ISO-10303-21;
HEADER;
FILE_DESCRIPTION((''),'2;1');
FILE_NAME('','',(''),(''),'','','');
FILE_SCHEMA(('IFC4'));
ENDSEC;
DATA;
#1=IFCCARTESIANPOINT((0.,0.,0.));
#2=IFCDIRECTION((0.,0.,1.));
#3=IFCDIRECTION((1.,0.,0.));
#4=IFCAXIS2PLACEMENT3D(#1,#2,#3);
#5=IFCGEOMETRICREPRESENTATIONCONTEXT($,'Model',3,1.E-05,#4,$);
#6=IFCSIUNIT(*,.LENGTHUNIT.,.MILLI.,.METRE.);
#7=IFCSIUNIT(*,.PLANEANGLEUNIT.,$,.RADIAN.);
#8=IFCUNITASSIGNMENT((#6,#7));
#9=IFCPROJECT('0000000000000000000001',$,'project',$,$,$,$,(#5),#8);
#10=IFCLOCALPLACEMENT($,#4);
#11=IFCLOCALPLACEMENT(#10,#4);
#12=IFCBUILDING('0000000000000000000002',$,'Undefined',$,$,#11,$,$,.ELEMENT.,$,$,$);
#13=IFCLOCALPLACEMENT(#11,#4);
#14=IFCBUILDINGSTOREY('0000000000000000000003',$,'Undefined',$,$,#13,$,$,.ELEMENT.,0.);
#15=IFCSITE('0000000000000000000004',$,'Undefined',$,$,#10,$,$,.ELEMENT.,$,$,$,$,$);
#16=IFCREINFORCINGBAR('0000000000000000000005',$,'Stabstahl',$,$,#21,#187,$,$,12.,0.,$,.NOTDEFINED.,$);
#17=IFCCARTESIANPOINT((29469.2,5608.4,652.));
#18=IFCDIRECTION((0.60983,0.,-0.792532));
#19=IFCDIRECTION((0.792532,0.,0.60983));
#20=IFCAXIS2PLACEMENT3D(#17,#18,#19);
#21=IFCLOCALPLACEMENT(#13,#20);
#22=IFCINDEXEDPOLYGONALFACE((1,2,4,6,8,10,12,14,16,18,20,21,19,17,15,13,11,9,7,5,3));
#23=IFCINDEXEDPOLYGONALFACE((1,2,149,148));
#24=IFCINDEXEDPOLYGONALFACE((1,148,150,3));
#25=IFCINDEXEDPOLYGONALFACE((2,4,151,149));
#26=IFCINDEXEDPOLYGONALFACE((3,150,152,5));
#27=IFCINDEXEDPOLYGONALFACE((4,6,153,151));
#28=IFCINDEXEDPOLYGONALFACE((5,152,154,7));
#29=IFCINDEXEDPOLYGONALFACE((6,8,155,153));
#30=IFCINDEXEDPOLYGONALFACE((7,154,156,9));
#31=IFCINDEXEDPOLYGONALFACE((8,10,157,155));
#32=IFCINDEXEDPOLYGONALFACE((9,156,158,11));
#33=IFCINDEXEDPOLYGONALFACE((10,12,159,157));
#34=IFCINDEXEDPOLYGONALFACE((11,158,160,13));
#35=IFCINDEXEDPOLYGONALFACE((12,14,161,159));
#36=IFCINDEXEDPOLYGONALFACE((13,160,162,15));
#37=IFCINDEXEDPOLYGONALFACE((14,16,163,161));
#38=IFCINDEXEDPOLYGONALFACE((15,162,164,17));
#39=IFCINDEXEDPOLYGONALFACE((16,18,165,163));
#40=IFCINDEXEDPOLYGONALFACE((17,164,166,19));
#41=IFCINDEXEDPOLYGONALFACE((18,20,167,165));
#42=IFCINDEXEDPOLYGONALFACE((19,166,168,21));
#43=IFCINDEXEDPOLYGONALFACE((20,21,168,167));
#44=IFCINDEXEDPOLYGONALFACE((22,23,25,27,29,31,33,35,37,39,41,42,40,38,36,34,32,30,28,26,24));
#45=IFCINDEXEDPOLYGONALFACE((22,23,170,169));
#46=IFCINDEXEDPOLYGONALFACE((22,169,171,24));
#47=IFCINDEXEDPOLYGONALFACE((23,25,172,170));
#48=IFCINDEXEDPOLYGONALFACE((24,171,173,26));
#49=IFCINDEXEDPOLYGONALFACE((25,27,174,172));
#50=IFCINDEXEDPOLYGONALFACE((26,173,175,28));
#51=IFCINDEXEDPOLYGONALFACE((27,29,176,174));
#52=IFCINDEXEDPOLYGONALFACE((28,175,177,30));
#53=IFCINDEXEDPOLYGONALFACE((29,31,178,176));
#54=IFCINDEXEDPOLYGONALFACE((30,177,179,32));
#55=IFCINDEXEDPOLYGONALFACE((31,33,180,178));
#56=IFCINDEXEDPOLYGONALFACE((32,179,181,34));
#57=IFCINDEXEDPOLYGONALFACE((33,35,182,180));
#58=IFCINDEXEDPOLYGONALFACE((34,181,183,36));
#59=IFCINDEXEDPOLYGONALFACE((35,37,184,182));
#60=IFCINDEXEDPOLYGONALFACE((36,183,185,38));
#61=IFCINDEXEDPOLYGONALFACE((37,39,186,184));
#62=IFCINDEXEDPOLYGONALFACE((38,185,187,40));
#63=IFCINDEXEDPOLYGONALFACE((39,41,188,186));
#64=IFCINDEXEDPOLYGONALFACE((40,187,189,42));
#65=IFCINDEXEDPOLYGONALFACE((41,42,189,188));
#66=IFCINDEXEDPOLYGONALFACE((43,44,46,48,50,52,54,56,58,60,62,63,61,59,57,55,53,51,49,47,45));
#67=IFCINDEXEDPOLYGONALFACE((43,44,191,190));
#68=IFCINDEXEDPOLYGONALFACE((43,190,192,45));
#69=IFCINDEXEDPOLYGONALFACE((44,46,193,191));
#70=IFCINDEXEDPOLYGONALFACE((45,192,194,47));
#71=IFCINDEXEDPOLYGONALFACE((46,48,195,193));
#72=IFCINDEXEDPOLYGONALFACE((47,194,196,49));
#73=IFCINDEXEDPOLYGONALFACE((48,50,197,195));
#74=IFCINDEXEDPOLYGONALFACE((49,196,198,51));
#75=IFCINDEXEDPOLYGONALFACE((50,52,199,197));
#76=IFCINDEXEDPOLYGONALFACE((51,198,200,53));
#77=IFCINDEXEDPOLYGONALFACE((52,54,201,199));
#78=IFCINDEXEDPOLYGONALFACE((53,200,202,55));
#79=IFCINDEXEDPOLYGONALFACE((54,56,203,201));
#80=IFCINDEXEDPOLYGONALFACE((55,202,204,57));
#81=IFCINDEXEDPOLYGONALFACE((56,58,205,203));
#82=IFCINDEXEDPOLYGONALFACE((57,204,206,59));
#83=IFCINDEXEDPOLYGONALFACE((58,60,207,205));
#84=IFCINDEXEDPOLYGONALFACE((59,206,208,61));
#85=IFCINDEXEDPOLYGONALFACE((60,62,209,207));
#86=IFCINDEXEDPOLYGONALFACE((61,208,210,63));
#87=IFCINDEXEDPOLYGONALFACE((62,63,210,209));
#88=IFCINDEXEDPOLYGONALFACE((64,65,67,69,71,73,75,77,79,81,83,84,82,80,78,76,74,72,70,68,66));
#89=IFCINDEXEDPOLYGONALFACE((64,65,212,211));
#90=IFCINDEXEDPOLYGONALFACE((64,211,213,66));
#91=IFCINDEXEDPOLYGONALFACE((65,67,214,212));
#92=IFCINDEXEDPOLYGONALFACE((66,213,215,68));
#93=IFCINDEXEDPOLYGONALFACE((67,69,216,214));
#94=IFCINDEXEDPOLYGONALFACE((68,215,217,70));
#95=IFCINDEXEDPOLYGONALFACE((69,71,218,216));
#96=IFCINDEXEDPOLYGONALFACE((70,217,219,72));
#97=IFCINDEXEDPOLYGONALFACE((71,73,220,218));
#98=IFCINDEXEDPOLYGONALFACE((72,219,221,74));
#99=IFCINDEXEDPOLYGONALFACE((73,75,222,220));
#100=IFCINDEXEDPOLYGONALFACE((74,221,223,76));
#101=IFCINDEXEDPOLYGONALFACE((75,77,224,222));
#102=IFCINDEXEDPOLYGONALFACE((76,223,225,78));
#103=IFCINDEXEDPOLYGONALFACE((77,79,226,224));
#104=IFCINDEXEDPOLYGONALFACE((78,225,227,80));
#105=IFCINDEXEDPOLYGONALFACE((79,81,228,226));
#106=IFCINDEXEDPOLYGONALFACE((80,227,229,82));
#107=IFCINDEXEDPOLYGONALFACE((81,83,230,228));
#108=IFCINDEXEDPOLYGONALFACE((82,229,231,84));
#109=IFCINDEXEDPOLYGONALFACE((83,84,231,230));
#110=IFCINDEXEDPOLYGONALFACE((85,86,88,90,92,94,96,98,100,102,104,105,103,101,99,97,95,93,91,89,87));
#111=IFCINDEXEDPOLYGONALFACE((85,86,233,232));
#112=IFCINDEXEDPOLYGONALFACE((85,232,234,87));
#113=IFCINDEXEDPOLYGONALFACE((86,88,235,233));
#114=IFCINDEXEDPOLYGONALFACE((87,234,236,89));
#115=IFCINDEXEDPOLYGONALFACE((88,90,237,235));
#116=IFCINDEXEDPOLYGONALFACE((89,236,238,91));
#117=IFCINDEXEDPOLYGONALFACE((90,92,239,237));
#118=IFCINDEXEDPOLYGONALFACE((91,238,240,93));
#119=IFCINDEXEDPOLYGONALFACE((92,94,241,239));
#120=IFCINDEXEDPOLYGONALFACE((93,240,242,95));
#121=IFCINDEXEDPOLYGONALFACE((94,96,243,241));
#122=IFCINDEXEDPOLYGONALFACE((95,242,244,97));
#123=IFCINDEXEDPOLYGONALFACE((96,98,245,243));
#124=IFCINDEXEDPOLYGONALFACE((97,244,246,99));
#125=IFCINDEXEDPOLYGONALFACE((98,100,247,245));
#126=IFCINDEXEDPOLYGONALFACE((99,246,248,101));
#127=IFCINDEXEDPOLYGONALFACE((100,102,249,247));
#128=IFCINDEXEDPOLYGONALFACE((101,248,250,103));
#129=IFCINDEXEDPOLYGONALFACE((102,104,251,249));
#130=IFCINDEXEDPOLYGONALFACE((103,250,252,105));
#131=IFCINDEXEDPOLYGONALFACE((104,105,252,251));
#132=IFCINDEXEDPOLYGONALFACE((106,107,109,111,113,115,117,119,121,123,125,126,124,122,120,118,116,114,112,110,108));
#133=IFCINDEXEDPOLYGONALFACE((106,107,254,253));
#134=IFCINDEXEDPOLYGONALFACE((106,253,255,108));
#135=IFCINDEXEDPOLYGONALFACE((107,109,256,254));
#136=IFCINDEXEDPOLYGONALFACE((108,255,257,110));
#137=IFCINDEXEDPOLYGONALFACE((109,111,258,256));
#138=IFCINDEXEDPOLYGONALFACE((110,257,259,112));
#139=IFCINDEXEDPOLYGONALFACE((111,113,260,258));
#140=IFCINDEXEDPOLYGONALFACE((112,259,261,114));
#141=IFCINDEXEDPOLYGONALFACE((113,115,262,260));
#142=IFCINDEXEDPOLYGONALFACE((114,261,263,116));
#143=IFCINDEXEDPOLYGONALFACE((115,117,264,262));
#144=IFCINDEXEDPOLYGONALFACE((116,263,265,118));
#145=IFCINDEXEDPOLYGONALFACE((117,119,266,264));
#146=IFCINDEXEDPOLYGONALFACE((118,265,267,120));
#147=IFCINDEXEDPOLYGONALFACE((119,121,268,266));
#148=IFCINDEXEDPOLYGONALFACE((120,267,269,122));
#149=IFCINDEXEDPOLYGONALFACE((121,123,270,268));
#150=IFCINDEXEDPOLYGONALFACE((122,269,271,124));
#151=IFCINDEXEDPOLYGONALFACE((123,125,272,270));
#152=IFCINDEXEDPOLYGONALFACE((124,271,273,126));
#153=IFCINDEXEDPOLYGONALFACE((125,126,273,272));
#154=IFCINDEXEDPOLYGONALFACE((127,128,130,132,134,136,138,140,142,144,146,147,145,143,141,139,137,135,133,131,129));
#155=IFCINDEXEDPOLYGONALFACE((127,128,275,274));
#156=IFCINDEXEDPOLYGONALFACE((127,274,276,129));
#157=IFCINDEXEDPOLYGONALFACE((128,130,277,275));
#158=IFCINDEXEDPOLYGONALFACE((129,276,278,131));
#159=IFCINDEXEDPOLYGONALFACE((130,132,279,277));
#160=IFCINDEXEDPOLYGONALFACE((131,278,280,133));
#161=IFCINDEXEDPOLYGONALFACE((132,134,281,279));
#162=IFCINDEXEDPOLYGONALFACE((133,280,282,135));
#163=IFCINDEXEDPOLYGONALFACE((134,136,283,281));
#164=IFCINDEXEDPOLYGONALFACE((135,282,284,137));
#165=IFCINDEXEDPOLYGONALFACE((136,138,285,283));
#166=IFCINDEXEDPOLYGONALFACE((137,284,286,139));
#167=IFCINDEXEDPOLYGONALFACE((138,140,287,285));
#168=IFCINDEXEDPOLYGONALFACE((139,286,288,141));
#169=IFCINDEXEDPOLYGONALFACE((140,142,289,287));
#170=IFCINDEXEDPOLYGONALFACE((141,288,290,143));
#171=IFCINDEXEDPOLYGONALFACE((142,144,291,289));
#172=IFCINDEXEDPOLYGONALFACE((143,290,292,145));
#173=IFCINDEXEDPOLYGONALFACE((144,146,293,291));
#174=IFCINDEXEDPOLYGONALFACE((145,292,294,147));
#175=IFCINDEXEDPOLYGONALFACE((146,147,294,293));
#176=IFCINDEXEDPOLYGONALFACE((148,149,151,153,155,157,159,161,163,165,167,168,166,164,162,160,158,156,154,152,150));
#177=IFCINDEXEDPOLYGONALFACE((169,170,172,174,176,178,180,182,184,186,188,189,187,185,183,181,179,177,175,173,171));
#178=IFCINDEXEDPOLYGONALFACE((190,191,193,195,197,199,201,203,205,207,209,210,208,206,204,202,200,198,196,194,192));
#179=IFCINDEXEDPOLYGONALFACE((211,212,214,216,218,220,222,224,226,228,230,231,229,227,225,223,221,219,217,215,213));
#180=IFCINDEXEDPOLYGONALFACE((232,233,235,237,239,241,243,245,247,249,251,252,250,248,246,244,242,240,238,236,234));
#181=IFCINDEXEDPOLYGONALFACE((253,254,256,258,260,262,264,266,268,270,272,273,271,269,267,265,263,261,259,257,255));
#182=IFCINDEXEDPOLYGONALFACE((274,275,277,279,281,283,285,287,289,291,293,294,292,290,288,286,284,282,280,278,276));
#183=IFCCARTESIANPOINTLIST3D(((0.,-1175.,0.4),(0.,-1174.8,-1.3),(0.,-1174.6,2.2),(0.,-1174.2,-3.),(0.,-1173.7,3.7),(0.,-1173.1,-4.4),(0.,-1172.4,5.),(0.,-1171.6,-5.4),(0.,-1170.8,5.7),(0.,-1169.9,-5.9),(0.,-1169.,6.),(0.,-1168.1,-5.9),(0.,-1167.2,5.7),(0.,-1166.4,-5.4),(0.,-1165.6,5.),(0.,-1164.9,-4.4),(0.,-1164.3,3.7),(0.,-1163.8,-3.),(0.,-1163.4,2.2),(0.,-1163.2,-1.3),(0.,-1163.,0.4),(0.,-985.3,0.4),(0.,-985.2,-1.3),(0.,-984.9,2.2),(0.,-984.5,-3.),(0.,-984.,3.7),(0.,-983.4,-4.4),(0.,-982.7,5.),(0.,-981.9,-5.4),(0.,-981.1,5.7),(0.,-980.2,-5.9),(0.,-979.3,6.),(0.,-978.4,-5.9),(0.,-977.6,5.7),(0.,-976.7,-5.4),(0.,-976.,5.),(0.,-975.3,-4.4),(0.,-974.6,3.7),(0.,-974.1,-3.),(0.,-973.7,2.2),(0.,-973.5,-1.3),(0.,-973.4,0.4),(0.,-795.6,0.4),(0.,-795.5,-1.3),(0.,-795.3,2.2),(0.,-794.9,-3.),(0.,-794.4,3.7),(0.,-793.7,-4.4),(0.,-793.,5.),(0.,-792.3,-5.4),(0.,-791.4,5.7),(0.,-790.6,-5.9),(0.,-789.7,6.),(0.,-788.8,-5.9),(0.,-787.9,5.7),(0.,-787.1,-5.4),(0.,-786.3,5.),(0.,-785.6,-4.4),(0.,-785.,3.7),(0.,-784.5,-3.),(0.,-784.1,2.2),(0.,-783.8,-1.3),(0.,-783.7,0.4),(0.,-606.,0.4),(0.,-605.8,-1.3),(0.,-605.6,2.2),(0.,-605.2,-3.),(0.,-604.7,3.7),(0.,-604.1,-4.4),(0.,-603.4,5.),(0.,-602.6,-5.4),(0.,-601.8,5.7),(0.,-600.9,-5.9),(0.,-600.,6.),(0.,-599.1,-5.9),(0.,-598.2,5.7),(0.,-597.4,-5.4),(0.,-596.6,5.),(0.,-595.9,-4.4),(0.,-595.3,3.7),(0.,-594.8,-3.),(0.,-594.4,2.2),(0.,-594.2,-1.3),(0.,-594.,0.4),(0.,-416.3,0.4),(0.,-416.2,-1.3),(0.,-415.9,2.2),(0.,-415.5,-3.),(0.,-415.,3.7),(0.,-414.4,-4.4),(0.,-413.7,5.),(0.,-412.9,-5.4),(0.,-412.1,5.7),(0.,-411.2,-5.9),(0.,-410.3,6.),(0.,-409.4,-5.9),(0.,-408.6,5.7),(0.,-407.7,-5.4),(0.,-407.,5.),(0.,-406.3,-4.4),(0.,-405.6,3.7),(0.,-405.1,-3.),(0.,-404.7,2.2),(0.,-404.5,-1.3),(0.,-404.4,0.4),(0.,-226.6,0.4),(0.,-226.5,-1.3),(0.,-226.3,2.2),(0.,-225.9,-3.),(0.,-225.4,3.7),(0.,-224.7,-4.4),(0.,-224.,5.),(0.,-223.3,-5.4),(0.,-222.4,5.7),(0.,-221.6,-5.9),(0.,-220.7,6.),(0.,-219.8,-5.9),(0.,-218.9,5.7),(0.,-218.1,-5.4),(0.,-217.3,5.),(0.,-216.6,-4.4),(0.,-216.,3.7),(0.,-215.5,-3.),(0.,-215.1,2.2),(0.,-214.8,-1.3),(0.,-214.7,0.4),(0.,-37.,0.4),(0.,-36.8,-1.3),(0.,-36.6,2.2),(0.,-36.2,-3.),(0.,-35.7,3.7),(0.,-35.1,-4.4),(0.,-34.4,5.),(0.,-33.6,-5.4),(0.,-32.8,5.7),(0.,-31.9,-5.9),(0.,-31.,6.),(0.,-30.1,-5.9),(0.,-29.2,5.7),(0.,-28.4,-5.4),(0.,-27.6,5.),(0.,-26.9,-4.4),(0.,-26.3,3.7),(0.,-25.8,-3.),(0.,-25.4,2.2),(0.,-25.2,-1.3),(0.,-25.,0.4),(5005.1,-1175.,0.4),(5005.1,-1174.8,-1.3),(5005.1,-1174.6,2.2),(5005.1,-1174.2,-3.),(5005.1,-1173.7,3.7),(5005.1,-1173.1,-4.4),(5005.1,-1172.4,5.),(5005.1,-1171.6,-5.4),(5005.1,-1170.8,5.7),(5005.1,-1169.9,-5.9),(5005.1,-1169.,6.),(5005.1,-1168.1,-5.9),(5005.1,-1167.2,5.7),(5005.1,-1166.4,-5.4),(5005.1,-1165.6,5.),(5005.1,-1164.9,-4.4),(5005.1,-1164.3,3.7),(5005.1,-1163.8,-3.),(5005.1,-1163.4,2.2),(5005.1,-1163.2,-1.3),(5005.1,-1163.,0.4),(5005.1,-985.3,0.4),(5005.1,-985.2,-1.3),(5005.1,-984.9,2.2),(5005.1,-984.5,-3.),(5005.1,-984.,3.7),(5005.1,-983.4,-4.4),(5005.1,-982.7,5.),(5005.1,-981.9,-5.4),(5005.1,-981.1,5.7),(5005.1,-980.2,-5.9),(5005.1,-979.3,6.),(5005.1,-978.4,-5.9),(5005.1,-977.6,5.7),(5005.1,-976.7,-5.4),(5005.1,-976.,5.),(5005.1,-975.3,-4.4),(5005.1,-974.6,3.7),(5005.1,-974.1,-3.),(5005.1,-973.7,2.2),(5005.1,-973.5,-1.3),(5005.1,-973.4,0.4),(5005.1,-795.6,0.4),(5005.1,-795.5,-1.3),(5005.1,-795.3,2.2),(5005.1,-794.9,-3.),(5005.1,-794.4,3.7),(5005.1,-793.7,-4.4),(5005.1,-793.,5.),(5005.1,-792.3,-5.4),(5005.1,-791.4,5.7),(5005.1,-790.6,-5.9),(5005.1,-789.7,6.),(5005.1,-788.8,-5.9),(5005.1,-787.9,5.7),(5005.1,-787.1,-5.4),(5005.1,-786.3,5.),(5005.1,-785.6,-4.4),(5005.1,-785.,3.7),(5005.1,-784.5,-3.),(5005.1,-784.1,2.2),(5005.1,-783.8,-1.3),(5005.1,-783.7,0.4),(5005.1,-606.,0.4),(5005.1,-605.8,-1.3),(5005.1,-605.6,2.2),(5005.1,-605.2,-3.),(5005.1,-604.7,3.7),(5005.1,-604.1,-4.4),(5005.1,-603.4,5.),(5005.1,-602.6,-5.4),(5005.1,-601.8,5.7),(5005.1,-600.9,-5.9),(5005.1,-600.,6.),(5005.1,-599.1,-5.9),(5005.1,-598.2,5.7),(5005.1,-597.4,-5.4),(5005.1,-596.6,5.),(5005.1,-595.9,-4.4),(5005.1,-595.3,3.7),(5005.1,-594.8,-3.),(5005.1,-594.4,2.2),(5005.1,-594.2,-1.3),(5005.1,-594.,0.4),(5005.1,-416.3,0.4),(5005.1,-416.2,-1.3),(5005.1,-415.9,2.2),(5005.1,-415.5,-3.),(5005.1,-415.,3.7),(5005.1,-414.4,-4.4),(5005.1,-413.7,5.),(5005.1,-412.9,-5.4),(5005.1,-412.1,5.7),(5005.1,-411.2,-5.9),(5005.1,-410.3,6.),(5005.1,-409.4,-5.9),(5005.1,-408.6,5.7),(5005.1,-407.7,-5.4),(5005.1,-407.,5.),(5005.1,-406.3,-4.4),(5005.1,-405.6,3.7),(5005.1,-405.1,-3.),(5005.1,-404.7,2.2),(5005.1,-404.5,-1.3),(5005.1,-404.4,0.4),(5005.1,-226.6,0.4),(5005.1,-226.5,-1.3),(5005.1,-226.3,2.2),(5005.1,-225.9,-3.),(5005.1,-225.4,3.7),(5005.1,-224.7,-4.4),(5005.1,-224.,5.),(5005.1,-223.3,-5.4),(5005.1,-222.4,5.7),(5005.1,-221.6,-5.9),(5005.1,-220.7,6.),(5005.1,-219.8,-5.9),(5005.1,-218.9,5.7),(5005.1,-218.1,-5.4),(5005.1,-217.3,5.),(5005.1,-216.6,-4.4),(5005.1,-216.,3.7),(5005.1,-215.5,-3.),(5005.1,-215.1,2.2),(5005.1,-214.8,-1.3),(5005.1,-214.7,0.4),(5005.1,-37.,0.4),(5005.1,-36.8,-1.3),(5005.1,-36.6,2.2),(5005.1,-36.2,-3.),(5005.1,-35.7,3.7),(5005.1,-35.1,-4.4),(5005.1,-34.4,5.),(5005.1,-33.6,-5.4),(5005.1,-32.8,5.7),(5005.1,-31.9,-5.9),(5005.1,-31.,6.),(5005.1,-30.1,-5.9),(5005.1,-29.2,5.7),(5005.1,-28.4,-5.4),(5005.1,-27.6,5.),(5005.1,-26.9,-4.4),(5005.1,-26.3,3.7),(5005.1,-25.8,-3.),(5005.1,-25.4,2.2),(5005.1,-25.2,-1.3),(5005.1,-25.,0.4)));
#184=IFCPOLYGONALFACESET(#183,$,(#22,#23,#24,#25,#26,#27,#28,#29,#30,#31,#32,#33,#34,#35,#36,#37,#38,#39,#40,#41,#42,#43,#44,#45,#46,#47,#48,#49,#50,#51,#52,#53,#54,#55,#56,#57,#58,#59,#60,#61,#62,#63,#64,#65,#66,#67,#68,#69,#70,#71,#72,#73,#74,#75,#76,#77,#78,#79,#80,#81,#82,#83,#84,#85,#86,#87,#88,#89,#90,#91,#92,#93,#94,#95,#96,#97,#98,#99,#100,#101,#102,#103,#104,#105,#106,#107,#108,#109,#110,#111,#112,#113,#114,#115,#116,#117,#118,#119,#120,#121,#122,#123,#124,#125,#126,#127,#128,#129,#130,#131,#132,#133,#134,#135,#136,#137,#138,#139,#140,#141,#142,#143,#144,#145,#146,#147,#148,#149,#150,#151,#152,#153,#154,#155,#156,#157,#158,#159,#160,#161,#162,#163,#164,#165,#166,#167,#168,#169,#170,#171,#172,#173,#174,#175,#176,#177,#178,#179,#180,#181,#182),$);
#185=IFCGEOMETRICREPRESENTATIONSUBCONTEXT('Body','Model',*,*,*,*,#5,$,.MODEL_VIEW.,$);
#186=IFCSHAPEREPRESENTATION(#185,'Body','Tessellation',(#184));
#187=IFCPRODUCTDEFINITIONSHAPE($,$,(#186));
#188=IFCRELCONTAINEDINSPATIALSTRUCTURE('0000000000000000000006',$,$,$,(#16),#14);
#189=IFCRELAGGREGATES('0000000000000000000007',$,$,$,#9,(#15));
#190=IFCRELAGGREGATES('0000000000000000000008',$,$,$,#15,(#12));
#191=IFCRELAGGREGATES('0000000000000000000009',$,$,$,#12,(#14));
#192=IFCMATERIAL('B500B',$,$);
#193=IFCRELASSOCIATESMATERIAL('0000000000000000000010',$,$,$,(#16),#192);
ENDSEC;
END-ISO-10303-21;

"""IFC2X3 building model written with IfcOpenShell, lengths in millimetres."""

from ifc_helpers import new_model, entity, si_unit, frame, origin_with_axes, place, context, subcontext, project, spatial, source, transform, mapped, material, element, save


model = new_model("IFC2X3")

# Units and contexts
model_context = context("Model", 3, precision=1e-05, world=origin_with_axes())
body_context = subcontext(model_context, "Body", "Model", "MODEL_VIEW")
ifc_project = project(units=[si_unit("LENGTHUNIT", "METRE", prefix="MILLI"), si_unit("PLANEANGLEUNIT", "RADIAN")], contexts=[model_context])

# Site, building, storey
site_placement = place(None, origin_with_axes())
site = spatial("IfcSite", under=ifc_project, at=site_placement, Name="Undefined", CompositionType="ELEMENT")
building_placement = place(site_placement, origin_with_axes())
building = spatial("IfcBuilding", under=site, at=building_placement, Name="Undefined", CompositionType="ELEMENT")
storey_placement = place(building_placement, origin_with_axes())
storey = spatial("IfcBuildingStorey", under=building, at=storey_placement, Name="Undefined", CompositionType="ELEMENT", Elevation=0.0)

# Reinforcing bar
ifc_material_1 = material(Name="B500B")
shared_shape_1 = source(origin_with_axes(), body_context, "Body", "AdvancedSweptSolid", [
    entity("IfcSweptDiskSolid", entity("IfcTrimmedCurve", entity("IfcLine", entity("IfcCartesianPoint", [0.0, 0.0, 0.0]), entity("IfcVector", entity("IfcDirection", [1.0, 0.0, 0.0]), 1.0)), [entity("IfcParameterValue", 0.0)], [entity("IfcParameterValue", 5005.137747)], True, "PARAMETER"), 6.0, None, 0.0, 5005.1),
])
shared_shape_2 = source(origin_with_axes(), body_context, "Body", "AdvancedSweptSolid", [
    entity("IfcSweptDiskSolid", entity("IfcTrimmedCurve", entity("IfcLine", entity("IfcCartesianPoint", [0.0, 0.0, 0.0]), entity("IfcVector", entity("IfcDirection", [1.0, 0.0, 0.0]), 1.0)), [entity("IfcParameterValue", 0.0)], [entity("IfcParameterValue", 5005.137747)], True, "PARAMETER"), 6.0, None, 0.0, 5005.1),
])
shared_shape_3 = source(origin_with_axes(), body_context, "Body", "AdvancedSweptSolid", [
    entity("IfcSweptDiskSolid", entity("IfcTrimmedCurve", entity("IfcLine", entity("IfcCartesianPoint", [0.0, 0.0, 0.0]), entity("IfcVector", entity("IfcDirection", [1.0, 0.0, 0.0]), 1.0)), [entity("IfcParameterValue", 0.0)], [entity("IfcParameterValue", 5005.137747)], True, "PARAMETER"), 6.0, None, 0.0, 5005.1),
])
shared_shape_4 = source(origin_with_axes(), body_context, "Body", "AdvancedSweptSolid", [
    entity("IfcSweptDiskSolid", entity("IfcTrimmedCurve", entity("IfcLine", entity("IfcCartesianPoint", [0.0, 0.0, 0.0]), entity("IfcVector", entity("IfcDirection", [1.0, 0.0, 0.0]), 1.0)), [entity("IfcParameterValue", 0.0)], [entity("IfcParameterValue", 5005.137747)], True, "PARAMETER"), 6.0, None, 0.0, 5005.1),
])
shared_shape_5 = source(origin_with_axes(), body_context, "Body", "AdvancedSweptSolid", [
    entity("IfcSweptDiskSolid", entity("IfcTrimmedCurve", entity("IfcLine", entity("IfcCartesianPoint", [0.0, 0.0, 0.0]), entity("IfcVector", entity("IfcDirection", [1.0, 0.0, 0.0]), 1.0)), [entity("IfcParameterValue", 0.0)], [entity("IfcParameterValue", 5005.137747)], True, "PARAMETER"), 6.0, None, 0.0, 5005.1),
])
shared_shape_6 = source(origin_with_axes(), body_context, "Body", "AdvancedSweptSolid", [
    entity("IfcSweptDiskSolid", entity("IfcTrimmedCurve", entity("IfcLine", entity("IfcCartesianPoint", [0.0, 0.0, 0.0]), entity("IfcVector", entity("IfcDirection", [1.0, 0.0, 0.0]), 1.0)), [entity("IfcParameterValue", 0.0)], [entity("IfcParameterValue", 5005.137747)], True, "PARAMETER"), 6.0, None, 0.0, 5005.1),
])
shared_shape_7 = source(origin_with_axes(), body_context, "Body", "AdvancedSweptSolid", [
    entity("IfcSweptDiskSolid", entity("IfcTrimmedCurve", entity("IfcLine", entity("IfcCartesianPoint", [0.0, 0.0, 0.0]), entity("IfcVector", entity("IfcDirection", [1.0, 0.0, 0.0]), 1.0)), [entity("IfcParameterValue", 0.0)], [entity("IfcParameterValue", 5005.137747)], True, "PARAMETER"), 6.0, None, 0.0, 5005.1),
])
reinforcing_bar_1_placement = place(storey_placement, frame((29469.2, 5608.4, 652.0), z_axis=(0.60983, 0.0, -0.792532), x_axis=(0.792532, 0.0, 0.60983)))
element("IfcReinforcingBar", 1, at=reinforcing_bar_1_placement, inside=storey, material=ifc_material_1, Name="Stabstahl", BarRole="NOTDEFINED", CrossSectionArea=0.0, NominalDiameter=12.0, context=body_context, shape_type="MappedRepresentation", body=[
    mapped(shared_shape_1, transform((0.0, -1169.0, 0.0))),
    mapped(shared_shape_2, transform((0.0, -979.3, 0.0))),
    mapped(shared_shape_3, transform((0.0, -789.7, 0.0))),
    mapped(shared_shape_4, transform((0.0, -600.0, 0.0))),
    mapped(shared_shape_5, transform((0.0, -410.3, 0.0))),
    mapped(shared_shape_6, transform((0.0, -220.7, 0.0))),
    mapped(shared_shape_7, transform((0.0, -31.0, 0.0))),
])

save(model, "model.ifc")
